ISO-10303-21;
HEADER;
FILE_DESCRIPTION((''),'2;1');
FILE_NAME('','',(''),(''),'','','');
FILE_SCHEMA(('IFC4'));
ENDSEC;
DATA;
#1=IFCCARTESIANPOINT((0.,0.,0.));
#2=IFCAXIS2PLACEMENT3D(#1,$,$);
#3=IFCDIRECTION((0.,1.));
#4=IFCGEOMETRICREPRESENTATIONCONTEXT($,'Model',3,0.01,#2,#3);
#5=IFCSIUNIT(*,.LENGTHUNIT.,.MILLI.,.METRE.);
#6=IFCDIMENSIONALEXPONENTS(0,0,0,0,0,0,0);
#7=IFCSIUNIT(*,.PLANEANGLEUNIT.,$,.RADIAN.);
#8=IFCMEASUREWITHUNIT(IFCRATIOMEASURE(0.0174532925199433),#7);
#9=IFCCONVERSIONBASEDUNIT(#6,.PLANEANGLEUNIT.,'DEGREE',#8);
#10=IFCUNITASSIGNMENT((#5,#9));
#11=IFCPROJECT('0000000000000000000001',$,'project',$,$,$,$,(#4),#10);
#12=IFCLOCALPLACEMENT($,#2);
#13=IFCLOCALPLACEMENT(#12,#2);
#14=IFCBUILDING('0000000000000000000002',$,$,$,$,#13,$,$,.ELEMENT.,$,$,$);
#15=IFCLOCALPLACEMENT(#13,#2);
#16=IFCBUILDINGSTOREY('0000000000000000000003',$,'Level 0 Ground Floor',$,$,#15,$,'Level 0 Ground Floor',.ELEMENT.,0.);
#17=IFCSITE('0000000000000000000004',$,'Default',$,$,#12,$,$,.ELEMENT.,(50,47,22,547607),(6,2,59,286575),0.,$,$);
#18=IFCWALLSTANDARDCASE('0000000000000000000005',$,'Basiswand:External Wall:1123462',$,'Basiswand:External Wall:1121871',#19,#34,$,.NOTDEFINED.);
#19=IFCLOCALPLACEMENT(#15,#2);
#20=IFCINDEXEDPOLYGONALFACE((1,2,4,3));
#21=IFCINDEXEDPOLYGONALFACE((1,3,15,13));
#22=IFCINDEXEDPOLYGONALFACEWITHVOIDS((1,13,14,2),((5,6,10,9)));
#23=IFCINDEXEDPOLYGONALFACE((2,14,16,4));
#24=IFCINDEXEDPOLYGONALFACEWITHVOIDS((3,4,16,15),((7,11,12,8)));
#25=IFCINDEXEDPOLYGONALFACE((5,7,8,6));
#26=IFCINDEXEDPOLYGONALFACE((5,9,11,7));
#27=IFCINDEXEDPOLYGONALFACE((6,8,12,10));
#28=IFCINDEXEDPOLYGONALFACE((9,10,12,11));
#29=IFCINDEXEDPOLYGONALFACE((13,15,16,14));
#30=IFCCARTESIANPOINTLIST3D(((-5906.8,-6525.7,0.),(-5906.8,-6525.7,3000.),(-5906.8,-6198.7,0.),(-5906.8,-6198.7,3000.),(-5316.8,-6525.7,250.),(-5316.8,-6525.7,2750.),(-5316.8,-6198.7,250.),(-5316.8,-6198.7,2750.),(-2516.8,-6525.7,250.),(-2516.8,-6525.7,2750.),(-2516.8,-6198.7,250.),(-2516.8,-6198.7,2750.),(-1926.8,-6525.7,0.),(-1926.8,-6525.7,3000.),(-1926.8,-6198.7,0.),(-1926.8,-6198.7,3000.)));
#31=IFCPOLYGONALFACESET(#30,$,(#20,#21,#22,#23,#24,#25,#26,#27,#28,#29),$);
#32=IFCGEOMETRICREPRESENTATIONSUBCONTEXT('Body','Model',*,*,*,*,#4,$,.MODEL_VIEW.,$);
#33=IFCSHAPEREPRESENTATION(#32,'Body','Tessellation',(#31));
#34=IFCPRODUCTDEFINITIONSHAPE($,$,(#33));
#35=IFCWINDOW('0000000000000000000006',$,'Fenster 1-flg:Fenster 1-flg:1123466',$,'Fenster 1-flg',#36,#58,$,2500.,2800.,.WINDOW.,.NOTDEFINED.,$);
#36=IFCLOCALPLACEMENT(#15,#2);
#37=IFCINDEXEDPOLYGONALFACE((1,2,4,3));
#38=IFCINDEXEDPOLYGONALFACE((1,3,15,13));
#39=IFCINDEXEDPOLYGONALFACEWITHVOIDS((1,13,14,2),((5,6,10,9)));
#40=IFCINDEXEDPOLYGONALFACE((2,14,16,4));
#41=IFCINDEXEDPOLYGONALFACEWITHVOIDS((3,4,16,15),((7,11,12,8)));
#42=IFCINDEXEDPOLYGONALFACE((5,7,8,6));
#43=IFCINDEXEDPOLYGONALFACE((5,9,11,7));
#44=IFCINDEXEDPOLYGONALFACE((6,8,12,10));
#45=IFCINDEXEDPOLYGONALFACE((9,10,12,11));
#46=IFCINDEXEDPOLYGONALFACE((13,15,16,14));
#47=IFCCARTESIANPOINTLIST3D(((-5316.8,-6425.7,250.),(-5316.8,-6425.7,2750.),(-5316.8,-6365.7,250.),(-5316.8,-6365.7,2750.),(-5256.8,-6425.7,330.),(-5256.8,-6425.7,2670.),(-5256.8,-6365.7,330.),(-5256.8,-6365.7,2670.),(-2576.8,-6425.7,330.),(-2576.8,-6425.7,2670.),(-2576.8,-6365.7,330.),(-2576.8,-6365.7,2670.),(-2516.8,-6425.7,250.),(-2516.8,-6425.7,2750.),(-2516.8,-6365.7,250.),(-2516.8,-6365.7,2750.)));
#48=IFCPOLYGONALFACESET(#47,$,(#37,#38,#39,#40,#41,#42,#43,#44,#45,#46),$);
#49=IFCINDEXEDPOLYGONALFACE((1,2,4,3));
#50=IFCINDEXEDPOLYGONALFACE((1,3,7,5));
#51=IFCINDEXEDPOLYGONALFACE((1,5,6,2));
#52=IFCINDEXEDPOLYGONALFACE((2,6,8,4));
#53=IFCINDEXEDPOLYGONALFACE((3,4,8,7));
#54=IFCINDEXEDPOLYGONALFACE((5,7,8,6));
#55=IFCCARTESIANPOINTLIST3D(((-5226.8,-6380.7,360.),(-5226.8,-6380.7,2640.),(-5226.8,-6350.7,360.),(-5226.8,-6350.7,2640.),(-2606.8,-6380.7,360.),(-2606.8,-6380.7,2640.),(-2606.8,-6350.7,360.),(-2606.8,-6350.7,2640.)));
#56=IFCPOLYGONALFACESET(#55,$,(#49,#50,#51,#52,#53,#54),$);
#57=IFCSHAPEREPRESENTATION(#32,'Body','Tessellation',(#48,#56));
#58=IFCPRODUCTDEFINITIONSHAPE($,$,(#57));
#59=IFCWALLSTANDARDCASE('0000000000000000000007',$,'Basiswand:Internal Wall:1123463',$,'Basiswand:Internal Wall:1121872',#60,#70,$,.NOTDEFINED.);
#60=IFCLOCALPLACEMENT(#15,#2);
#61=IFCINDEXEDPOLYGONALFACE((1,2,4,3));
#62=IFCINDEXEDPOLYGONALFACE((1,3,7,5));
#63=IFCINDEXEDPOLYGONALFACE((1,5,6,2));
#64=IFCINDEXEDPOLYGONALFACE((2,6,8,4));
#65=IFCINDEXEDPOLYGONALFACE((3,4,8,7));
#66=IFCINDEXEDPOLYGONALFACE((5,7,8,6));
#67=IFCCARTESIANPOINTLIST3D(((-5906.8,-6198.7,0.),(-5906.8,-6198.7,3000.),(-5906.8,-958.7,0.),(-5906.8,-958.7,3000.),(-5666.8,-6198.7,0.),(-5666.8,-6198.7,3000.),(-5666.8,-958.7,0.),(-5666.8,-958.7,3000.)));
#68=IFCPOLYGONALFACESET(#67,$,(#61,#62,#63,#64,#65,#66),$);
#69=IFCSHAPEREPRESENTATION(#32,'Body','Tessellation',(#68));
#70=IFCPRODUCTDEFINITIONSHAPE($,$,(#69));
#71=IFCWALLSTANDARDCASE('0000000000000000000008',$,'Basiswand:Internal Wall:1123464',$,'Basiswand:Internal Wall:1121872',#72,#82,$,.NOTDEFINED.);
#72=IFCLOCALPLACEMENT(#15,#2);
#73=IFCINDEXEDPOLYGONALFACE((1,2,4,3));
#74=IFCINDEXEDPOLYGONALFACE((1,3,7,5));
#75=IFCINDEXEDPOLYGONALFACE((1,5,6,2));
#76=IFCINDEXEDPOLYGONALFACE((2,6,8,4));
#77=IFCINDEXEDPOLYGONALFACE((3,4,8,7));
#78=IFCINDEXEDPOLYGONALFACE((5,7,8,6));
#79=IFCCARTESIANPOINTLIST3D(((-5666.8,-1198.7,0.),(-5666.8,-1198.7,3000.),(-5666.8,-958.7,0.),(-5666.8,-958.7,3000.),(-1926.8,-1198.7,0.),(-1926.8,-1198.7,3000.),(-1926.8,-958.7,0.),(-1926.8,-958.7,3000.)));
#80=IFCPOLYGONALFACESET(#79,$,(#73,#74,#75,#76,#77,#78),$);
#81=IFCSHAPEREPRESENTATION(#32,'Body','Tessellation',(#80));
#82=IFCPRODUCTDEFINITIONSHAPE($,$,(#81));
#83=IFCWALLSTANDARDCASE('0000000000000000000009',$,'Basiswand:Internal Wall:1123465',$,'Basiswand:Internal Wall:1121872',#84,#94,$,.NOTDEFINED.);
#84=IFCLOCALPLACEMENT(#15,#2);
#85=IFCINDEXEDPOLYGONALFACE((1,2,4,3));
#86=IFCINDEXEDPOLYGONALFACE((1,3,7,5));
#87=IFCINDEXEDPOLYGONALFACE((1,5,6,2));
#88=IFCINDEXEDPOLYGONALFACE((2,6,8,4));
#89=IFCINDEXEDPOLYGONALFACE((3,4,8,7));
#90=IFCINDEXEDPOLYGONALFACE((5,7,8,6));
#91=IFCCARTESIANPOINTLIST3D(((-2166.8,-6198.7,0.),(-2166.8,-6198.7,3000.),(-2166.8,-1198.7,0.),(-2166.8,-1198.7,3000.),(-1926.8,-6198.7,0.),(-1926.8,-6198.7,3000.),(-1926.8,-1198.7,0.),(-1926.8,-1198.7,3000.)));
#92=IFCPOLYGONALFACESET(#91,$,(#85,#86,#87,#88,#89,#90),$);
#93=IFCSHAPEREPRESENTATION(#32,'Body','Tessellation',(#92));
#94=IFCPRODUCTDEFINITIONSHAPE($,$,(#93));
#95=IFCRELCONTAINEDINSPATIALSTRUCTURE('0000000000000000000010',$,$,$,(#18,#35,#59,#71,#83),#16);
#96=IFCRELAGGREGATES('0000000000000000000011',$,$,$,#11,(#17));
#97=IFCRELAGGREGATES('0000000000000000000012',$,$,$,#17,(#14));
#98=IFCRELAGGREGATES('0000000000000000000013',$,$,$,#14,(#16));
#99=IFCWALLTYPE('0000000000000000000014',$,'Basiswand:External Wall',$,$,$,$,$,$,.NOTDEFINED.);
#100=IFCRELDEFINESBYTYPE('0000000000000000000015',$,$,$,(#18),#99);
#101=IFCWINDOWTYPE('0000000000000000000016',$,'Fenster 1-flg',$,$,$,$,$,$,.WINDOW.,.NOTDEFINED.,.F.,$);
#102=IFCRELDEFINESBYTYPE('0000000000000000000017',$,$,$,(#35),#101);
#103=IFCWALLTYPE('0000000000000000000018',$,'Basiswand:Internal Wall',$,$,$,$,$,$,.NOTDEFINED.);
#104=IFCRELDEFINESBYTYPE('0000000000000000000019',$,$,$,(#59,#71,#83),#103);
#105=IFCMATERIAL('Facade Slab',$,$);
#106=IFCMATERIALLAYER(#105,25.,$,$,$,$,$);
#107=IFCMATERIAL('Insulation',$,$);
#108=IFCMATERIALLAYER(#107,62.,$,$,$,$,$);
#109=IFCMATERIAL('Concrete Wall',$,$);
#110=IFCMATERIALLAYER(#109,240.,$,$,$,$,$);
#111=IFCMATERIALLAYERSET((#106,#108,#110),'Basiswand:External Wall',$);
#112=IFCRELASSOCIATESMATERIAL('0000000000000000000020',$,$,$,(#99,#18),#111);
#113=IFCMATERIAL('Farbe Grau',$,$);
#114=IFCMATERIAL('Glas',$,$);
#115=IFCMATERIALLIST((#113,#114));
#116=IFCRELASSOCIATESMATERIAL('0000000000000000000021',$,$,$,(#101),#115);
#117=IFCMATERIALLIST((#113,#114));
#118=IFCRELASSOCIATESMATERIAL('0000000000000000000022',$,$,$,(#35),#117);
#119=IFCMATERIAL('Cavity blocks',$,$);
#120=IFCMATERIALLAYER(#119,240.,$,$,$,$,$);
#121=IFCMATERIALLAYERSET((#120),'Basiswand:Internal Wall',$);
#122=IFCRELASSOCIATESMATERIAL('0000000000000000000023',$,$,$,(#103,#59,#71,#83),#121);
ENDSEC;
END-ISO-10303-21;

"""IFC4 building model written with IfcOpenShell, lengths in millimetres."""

from ifc_helpers import new_model, entity, si_unit, converted_unit, direction, frame, frame_2d, origin, origin_2d_with_axis, place, context, subcontext, project, spatial, polyline, rectangle, outline, extrude, clip, bounded_halfspace, source, transform, mapped, material, material_list, layer, layer_set, layer_usage, type_object, type_shapes, element, fill, save


model = new_model("IFC4")

# Units and contexts
model_context = context("Model", 3, precision=0.01, world=origin(), true_north=direction((0.0, 1.0)))
body_context = subcontext(model_context, "Body", "Model", "MODEL_VIEW")
ifc_project = project(units=[si_unit("LENGTHUNIT", "METRE", prefix="MILLI"), converted_unit("PLANEANGLEUNIT", "DEGREE", entity("IfcRatioMeasure", 0.0174532925199433), si_unit("PLANEANGLEUNIT", "RADIAN"), dimensions=[0, 0, 0, 0, 0, 0, 0])], contexts=[model_context])

# Site, building, storey
site_placement = place(None, origin())
site = spatial("IfcSite", under=ifc_project, at=site_placement, Name="Default", CompositionType="ELEMENT", RefLatitude=(50, 47, 22, 547607), RefLongitude=(6, 2, 59, 286575), RefElevation=0.0)
building_placement = place(site_placement, origin())
building = spatial("IfcBuilding", under=site, at=building_placement, CompositionType="ELEMENT")
storey_placement = place(building_placement, origin())
storey = spatial("IfcBuildingStorey", under=building, at=storey_placement, Name="Level 0 Ground Floor", LongName="Level 0 Ground Floor", CompositionType="ELEMENT", Elevation=0.0)

# Wall, opening, window
ifc_material_1 = material(Name="Facade Slab")
ifc_layer_1 = layer(ifc_material_1, 25.0)
ifc_material_2 = material(Name="Insulation")
ifc_layer_2 = layer(ifc_material_2, 62.0)
ifc_material_3 = material(Name="Concrete Wall")
ifc_layer_3 = layer(ifc_material_3, 240.0)
ifc_layer_set_1 = layer_set([ifc_layer_1, ifc_layer_2, ifc_layer_3], Name="Basiswand:External Wall")
ifc_layer_usage_1 = layer_usage(ifc_layer_set_1, "AXIS2", "POSITIVE", -163.5)
wall_type_1 = type_object("IfcWallType", Name="Basiswand:External Wall", PredefinedType="NOTDEFINED", material=ifc_layer_set_1)
wall_1_placement = place(storey_placement, frame((-5906.8, -6362.2, 0.0)))
wall_1 = element("IfcWallStandardCase", 1, at=wall_1_placement, inside=storey, type_object=wall_type_1, material=ifc_layer_usage_1, Name="Basiswand:External Wall:1123462", ObjectType="Basiswand:External Wall:1121871", PredefinedType="NOTDEFINED", context=body_context, shape_type="Clipping", body=[
    clip(extrude(rectangle(XDim=3980.0, YDim=327.0, at=frame_2d((1990.0, 0.0), x_axis=(-1.0, 0.0))), origin(), (0.0, 0.0, 1.0), 3000.0), bounded_halfspace(frame((0.0, -163.5, 3000.0), z_axis=(0.0, 0.0, -1.0), x_axis=(0.0, -1.0, 0.0)), True, frame((0.0, -163.5, 3000.0)), polyline([(0.0, 0.0), (3980.0, 0.0), (3980.0, 327.0), (3740.0, 327.0), (240.0, 327.0), (0.0, 327.0), (0.0, 0.0)]))),
])
opening_placement = place(wall_1_placement, frame((590.0, -163.5, 250.0)))
opening = element("IfcOpeningElement", 2, at=opening_placement, cuts=wall_1, ObjectType="Opening", PredefinedType="OPENING", context=body_context, shape_type="SweptSolid", body=[
    extrude(rectangle(XDim=2500.0, YDim=2800.0, at=frame_2d((1250.0, 1400.0), x_axis=(1.0, 0.0))), frame((0.0, 0.0, 0.0), z_axis=(0.0, 1.0, 0.0), x_axis=(0.0, 0.0, 1.0)), (0.0, 0.0, 1.0), 327.0),
])
ifc_material_4 = material(Name="Farbe Grau")
ifc_material_5 = material(Name="Glas")
ifc_material_list_1 = material_list([ifc_material_4, ifc_material_5])
ifc_material_list_2 = material_list([ifc_material_4, ifc_material_5])
window_type = type_object("IfcWindowType", Name="Fenster 1-flg", ParameterTakesPrecedence=False, PartitioningType="NOTDEFINED", PredefinedType="WINDOW", material=ifc_material_list_2)
shared_shape_1 = source(origin(), body_context, "Body", "SweptSolid", [
    extrude(outline(polyline([(-1250.0, -1400.0), (1250.0, -1400.0), (1250.0, 1400.0), (-1250.0, 1400.0), (-1250.0, -1400.0)]), holes=[polyline([(-1170.0, -1340.0), (-1170.0, 1340.0), (1170.0, 1340.0), (1170.0, -1340.0), (-1170.0, -1340.0)])]), frame((1400.0, 167.0, 1250.0), z_axis=(0.0, 1.0, 0.0), x_axis=(0.0, 0.0, -1.0)), (0.0, 0.0, 1.0), 60.0),
    extrude(rectangle(XDim=30.0, YDim=2620.0, at=origin_2d_with_axis()), frame((1400.0, 167.0, 110.0), z_axis=(0.0, 0.0, 1.0), x_axis=(0.0, 1.0, 0.0)), (0.0, 0.0, 1.0), 2280.0),
])
type_shapes(window_type, [shared_shape_1])
window_placement = place(opening_placement, frame((2800.0, 327.0, 0.0), z_axis=(0.0, 0.0, 1.0), x_axis=(-1.0, 0.0, 0.0)))
window = element("IfcWindow", 3, at=window_placement, inside=storey, type_object=window_type, material=ifc_material_list_1, Name="Fenster 1-flg:Fenster 1-flg:1123466", ObjectType="Fenster 1-flg", OverallHeight=2500.0, OverallWidth=2800.0, PartitioningType="NOTDEFINED", PredefinedType="WINDOW", context=body_context, shape_type="MappedRepresentation", body=[
    mapped(shared_shape_1, transform((0.0, 0.0, 0.0), scale=1.0)),
])
fill(opening, window)

# Walls
ifc_material_6 = material(Name="Cavity blocks")
ifc_layer_4 = layer(ifc_material_6, 240.0)
ifc_layer_set_2 = layer_set([ifc_layer_4], Name="Basiswand:Internal Wall")
ifc_layer_usage_2 = layer_usage(ifc_layer_set_2, "AXIS2", "NEGATIVE", 120.0)
wall_type_2 = type_object("IfcWallType", Name="Basiswand:Internal Wall", PredefinedType="NOTDEFINED", material=ifc_layer_set_2)
wall_2_placement = place(storey_placement, frame((-5786.8, -6198.7, 0.0), z_axis=(0.0, 0.0, 1.0), x_axis=(0.0, 1.0, 0.0)))
element("IfcWallStandardCase", 4, at=wall_2_placement, inside=storey, type_object=wall_type_2, material=ifc_layer_usage_2, Name="Basiswand:Internal Wall:1123463", ObjectType="Basiswand:Internal Wall:1121872", PredefinedType="NOTDEFINED", context=body_context, shape_type="Clipping", body=[
    clip(extrude(rectangle(XDim=5240.0, YDim=240.0, at=frame_2d((2620.0, 0.0), x_axis=(-1.0, 0.0))), origin(), (0.0, 0.0, 1.0), 3000.0), bounded_halfspace(frame((0.0, -120.0, 3000.0), z_axis=(0.0, 0.0, -1.0), x_axis=(-1.0, 0.0, 0.0)), True, frame((0.0, -120.0, 3000.0)), polyline([(0.0, 0.0), (5000.0, 0.0), (5240.0, 0.0), (5240.0, 240.0), (0.0, 240.0), (0.0, 0.0)]))),
])
ifc_layer_usage_3 = layer_usage(ifc_layer_set_2, "AXIS2", "NEGATIVE", 120.0)
wall_3_placement = place(storey_placement, frame((-5666.8, -1078.7, 0.0)))
element("IfcWallStandardCase", 5, at=wall_3_placement, inside=storey, type_object=wall_type_2, material=ifc_layer_usage_3, Name="Basiswand:Internal Wall:1123464", ObjectType="Basiswand:Internal Wall:1121872", PredefinedType="NOTDEFINED", context=body_context, shape_type="Clipping", body=[
    clip(extrude(rectangle(XDim=3740.0, YDim=240.0, at=frame_2d((1870.0, 0.0), x_axis=(-1.0, 0.0))), origin(), (0.0, 0.0, 1.0), 3000.0), bounded_halfspace(frame((0.0, -120.0, 3000.0), z_axis=(0.0, 0.0, -1.0), x_axis=(0.0, -1.0, 0.0)), True, frame((0.0, -120.0, 3000.0)), polyline([(0.0, 0.0), (3500.0, 0.0), (3740.0, 0.0), (3740.0, 240.0), (0.0, 240.0), (0.0, 0.0)]))),
])
ifc_layer_usage_4 = layer_usage(ifc_layer_set_2, "AXIS2", "NEGATIVE", 120.0)
wall_4_placement = place(storey_placement, frame((-2046.8, -1198.7, 0.0), z_axis=(0.0, 0.0, 1.0), x_axis=(0.0, -1.0, 0.0)))
element("IfcWallStandardCase", 6, at=wall_4_placement, inside=storey, type_object=wall_type_2, material=ifc_layer_usage_4, Name="Basiswand:Internal Wall:1123465", ObjectType="Basiswand:Internal Wall:1121872", PredefinedType="NOTDEFINED", context=body_context, shape_type="Clipping", body=[
    clip(extrude(rectangle(XDim=5000.0, YDim=240.0, at=frame_2d((2500.0, 0.0), x_axis=(-1.0, 0.0))), origin(), (0.0, 0.0, 1.0), 3000.0), bounded_halfspace(frame((0.0, -120.0, 3000.0), z_axis=(0.0, 0.0, -1.0), x_axis=(1.0, 0.0, 0.0)), True, frame((0.0, -120.0, 3000.0)), polyline([(0.0, 0.0), (5000.0, 0.0), (5000.0, 240.0), (0.0, 240.0), (0.0, 0.0)]))),
])

save(model, "model.ifc")
